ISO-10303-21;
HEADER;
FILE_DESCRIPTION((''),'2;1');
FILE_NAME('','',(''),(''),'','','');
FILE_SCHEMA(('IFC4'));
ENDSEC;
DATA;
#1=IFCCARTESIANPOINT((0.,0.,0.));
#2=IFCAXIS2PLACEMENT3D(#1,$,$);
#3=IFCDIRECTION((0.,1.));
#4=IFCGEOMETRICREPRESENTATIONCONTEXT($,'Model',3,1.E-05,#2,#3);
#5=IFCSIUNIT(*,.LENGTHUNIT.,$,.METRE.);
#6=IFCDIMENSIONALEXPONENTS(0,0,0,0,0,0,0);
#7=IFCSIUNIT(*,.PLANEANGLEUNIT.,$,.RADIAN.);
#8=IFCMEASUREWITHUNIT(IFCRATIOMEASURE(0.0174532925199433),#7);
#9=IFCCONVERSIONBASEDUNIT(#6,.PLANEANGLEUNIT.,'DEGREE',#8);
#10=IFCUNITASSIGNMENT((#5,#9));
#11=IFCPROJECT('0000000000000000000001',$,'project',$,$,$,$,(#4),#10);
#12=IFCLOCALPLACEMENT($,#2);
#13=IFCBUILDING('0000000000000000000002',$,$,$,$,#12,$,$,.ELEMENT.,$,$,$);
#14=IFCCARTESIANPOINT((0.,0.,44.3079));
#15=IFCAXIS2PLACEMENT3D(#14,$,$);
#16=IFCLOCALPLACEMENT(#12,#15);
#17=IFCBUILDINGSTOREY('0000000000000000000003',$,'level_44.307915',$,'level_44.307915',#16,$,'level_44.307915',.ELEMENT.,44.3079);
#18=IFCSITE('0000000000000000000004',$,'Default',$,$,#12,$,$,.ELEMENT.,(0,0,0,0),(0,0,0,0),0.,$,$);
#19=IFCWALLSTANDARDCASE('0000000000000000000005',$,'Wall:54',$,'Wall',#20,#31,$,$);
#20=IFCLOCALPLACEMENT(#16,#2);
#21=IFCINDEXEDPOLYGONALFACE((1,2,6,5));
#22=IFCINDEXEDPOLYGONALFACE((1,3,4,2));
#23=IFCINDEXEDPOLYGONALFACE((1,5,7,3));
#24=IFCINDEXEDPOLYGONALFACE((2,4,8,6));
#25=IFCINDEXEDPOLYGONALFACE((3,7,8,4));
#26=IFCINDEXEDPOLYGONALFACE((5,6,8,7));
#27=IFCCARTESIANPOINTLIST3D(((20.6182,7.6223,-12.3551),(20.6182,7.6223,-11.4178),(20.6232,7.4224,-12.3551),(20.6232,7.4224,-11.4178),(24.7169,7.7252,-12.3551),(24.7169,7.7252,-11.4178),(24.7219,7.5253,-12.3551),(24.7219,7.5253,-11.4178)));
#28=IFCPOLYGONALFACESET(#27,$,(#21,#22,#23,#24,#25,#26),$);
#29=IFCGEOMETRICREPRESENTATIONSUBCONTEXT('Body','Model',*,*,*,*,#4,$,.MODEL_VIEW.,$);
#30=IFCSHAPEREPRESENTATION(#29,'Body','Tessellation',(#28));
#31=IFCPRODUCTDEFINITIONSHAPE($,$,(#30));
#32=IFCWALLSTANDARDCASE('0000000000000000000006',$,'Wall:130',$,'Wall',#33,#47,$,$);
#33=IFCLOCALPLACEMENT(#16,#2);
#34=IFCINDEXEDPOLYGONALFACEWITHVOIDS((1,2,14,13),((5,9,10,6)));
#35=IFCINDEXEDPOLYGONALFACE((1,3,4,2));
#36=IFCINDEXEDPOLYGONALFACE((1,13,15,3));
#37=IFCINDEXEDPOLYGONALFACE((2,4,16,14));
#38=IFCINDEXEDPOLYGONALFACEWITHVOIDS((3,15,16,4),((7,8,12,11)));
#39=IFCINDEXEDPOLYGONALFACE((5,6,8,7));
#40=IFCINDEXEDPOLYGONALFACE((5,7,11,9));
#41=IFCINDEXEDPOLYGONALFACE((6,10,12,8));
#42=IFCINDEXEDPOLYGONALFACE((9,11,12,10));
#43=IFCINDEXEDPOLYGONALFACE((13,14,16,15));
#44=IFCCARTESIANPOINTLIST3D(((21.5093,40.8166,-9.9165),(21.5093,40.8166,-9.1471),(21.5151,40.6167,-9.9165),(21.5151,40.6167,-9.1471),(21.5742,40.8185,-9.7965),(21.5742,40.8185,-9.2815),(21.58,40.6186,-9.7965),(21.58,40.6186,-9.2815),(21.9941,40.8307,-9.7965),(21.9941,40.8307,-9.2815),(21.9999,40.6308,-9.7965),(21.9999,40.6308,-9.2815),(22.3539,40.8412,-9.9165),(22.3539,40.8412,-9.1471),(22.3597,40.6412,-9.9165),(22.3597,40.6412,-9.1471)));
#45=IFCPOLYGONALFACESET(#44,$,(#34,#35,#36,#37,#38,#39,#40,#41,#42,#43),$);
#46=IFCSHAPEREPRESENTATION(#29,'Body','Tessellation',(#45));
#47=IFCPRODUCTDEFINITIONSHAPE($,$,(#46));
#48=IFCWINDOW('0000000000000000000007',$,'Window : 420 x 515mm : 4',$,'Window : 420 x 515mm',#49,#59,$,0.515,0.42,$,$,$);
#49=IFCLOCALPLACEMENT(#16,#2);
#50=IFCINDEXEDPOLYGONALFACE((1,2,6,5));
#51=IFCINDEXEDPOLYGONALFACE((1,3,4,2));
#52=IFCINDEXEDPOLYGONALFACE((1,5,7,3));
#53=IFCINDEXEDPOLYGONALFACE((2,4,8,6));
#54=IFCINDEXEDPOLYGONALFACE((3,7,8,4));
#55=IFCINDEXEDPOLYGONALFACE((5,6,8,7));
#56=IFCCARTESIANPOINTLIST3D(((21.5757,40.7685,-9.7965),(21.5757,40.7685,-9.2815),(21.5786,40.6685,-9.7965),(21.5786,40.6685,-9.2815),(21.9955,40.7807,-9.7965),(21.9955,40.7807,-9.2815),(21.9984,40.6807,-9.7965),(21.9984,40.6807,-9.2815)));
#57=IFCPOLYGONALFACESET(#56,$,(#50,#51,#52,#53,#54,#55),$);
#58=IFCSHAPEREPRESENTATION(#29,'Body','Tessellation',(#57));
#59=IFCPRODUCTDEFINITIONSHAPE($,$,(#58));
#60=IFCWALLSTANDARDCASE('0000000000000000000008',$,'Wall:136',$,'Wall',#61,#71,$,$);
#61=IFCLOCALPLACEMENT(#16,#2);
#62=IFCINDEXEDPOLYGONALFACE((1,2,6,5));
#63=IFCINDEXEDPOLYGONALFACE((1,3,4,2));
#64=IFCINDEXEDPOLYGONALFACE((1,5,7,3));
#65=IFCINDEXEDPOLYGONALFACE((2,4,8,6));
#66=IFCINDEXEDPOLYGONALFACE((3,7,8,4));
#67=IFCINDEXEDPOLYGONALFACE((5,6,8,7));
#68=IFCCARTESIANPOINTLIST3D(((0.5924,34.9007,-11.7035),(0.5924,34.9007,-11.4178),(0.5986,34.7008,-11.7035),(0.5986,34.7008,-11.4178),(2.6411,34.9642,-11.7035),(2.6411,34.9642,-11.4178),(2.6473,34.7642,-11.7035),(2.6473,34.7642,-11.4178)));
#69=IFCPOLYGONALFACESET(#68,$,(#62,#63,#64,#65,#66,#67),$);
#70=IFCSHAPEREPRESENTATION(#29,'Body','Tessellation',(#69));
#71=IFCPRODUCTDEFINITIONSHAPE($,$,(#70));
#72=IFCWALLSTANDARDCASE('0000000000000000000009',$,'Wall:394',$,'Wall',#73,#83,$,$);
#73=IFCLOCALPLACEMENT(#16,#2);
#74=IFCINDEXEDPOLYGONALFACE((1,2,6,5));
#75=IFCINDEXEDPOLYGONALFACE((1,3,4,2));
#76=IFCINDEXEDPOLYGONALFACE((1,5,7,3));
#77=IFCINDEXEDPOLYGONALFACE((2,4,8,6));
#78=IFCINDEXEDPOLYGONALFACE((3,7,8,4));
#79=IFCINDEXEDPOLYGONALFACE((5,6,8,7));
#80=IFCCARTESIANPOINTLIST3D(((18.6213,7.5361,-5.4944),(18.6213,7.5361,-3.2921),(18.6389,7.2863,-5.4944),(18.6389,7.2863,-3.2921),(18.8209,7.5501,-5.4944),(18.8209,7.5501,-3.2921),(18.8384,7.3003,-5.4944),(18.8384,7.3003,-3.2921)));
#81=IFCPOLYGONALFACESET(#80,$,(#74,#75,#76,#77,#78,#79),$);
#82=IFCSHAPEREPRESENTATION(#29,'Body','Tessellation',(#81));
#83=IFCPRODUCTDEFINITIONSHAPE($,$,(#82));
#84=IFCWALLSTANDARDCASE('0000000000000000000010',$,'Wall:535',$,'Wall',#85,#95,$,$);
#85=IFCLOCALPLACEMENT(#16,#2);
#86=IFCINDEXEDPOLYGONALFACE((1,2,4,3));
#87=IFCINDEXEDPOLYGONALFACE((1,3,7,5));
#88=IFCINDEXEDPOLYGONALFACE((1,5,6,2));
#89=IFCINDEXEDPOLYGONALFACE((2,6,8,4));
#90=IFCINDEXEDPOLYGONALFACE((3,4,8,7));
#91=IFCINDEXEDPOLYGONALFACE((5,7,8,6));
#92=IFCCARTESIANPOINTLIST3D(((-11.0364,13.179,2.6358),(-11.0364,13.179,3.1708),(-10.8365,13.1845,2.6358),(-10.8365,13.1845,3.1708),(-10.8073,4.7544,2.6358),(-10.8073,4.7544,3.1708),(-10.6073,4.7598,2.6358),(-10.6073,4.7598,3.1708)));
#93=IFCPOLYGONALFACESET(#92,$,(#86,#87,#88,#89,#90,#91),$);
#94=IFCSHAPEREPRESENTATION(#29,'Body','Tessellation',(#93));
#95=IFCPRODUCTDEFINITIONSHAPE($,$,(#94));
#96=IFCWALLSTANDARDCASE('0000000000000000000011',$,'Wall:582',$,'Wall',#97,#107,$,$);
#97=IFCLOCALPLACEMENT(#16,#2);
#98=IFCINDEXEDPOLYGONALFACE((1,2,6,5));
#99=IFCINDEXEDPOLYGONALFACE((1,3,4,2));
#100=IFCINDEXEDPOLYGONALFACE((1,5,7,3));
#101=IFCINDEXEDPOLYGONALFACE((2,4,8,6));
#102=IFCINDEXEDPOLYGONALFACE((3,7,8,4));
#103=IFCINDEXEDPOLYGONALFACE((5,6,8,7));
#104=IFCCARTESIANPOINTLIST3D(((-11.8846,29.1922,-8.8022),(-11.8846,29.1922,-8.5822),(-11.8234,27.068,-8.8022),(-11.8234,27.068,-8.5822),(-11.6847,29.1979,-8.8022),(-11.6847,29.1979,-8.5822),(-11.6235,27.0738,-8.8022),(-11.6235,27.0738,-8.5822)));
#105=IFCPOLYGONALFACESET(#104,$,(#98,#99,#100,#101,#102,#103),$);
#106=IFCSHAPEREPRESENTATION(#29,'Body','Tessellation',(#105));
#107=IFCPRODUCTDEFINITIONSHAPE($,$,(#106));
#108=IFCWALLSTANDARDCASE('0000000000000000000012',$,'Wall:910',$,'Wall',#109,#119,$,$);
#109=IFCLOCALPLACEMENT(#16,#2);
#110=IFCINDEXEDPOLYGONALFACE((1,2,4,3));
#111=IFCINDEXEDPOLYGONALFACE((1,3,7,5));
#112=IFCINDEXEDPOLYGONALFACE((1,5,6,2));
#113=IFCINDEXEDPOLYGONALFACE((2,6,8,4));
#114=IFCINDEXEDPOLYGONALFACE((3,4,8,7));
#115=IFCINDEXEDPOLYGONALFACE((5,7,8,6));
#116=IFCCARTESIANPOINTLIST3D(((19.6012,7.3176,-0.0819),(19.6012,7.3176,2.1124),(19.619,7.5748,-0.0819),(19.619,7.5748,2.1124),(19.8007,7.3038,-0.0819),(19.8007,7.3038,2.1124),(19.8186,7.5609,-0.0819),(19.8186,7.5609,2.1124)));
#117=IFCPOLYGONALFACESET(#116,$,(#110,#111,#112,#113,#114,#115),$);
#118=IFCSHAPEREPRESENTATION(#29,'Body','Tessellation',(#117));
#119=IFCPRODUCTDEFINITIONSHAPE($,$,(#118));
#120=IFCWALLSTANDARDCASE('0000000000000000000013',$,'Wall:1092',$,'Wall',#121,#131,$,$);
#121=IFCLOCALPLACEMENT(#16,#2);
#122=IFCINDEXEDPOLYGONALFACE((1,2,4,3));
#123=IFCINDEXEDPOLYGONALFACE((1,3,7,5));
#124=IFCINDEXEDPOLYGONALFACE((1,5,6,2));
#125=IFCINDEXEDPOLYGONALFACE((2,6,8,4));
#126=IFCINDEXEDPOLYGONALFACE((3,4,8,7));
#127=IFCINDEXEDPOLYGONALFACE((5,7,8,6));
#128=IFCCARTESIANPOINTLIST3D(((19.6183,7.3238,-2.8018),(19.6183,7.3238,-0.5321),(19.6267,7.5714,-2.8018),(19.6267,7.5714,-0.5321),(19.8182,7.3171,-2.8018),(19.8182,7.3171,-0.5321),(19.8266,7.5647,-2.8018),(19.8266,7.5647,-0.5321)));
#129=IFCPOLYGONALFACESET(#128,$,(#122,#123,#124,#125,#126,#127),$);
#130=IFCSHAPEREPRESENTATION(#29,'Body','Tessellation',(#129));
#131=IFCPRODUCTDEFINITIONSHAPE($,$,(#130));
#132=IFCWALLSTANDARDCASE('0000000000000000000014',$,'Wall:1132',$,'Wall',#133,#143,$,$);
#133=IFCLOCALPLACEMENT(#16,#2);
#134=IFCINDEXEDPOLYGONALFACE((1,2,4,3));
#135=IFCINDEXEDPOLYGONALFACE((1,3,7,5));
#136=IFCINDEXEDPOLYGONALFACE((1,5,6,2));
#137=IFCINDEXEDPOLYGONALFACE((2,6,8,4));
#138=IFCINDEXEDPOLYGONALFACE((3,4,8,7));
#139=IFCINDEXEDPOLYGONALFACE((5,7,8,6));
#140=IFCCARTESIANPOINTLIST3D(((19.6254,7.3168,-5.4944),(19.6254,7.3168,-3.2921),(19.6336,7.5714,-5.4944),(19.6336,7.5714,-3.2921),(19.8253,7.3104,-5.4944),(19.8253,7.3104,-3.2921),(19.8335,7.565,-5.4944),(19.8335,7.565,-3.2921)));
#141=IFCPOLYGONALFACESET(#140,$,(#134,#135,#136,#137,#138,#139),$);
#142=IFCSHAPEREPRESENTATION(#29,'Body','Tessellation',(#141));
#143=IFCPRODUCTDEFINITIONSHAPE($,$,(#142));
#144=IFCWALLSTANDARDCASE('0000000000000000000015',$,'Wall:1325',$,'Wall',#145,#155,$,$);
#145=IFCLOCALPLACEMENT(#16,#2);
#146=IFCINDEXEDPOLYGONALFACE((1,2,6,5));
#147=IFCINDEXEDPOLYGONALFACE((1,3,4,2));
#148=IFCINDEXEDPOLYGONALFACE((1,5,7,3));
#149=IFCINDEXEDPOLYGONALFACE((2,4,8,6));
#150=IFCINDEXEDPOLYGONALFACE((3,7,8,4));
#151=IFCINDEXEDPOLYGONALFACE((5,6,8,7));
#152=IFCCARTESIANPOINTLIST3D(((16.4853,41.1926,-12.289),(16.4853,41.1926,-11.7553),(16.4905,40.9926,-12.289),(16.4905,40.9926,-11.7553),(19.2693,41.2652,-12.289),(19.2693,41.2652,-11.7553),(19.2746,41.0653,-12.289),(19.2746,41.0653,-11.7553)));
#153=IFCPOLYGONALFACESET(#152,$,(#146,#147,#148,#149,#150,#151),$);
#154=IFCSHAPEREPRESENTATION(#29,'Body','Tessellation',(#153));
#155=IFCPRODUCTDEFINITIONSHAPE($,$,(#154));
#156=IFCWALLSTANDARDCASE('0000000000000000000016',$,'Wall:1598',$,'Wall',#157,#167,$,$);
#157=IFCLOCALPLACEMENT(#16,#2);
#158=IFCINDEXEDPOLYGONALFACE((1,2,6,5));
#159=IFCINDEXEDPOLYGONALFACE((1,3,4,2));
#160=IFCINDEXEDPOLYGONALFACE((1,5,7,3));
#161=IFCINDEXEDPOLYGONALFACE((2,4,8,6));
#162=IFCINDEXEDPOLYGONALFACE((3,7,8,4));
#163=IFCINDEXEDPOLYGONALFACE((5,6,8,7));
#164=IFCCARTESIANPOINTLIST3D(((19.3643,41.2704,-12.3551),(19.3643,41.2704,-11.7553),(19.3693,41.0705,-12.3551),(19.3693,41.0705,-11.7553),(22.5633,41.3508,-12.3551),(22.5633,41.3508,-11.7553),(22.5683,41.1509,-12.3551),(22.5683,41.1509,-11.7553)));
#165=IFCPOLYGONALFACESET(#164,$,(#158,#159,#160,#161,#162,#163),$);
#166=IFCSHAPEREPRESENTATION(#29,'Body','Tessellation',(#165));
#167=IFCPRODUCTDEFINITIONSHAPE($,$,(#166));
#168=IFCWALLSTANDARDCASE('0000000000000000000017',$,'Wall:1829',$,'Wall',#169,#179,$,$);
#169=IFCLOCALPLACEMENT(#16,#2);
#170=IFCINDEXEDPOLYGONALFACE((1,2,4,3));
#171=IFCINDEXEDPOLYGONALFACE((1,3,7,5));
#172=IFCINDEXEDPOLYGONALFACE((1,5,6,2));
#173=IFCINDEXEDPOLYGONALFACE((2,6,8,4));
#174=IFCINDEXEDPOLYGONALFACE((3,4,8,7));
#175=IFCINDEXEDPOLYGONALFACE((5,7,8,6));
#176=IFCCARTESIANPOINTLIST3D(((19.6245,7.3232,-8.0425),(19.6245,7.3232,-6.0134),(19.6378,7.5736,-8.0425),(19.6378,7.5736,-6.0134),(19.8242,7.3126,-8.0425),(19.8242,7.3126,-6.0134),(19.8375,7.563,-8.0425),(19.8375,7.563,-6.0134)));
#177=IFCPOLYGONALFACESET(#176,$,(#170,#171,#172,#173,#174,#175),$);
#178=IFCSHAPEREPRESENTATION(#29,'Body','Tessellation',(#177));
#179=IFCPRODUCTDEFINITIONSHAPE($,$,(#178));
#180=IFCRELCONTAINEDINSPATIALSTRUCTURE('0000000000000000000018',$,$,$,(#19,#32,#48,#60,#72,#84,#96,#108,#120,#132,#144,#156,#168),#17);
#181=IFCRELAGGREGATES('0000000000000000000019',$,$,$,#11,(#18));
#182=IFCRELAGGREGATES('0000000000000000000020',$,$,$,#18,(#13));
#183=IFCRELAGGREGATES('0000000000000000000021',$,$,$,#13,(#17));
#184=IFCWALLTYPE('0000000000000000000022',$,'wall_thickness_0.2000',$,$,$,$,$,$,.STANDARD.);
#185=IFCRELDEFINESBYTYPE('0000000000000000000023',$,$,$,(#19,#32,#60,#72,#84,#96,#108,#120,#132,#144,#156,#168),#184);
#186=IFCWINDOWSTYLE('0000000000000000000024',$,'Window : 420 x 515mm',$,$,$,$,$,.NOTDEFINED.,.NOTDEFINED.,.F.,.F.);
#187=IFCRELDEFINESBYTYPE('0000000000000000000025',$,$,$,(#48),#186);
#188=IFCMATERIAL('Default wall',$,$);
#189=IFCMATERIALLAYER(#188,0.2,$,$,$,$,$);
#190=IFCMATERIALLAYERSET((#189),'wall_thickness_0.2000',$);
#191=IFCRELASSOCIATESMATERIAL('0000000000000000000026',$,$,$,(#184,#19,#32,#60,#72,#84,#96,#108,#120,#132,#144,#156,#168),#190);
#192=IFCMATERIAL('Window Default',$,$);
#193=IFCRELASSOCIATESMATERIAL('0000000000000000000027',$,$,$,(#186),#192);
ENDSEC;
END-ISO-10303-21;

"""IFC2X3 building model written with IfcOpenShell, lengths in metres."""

from ifc_helpers import new_model, entity, si_unit, converted_unit, direction, frame, frame_2d, origin, origin_2d_with_axis, place, context, subcontext, project, spatial, polyline, rectangle, outline, extrude, source, transform, mapped, material, layer, layer_set, layer_usage, type_object, type_shapes, element, fill, save


model = new_model("IFC2X3")

# Units and contexts
model_context = context("Model", 3, precision=1e-05, world=origin(), true_north=direction((0.0, 1.0)))
body_context = subcontext(model_context, "Body", "Model", "MODEL_VIEW")
ifc_project = project(units=[si_unit("LENGTHUNIT", "METRE"), converted_unit("PLANEANGLEUNIT", "DEGREE", entity("IfcRatioMeasure", 0.0174532925199433), si_unit("PLANEANGLEUNIT", "RADIAN"), dimensions=[0, 0, 0, 0, 0, 0, 0])], contexts=[model_context])

# Site, building, storey
placement_1 = place(None, origin())
site = spatial("IfcSite", under=ifc_project, at=placement_1, Name="Default", CompositionType="ELEMENT", RefLatitude=(0, 0, 0, 0), RefLongitude=(0, 0, 0, 0), RefElevation=0.0)
building = spatial("IfcBuilding", under=site, at=placement_1, CompositionType="ELEMENT")
storey_placement = place(placement_1, frame((0.0, 0.0, 44.3079)))
storey = spatial("IfcBuildingStorey", under=building, at=storey_placement, Name="level_44.307915", ObjectType="level_44.307915", LongName="level_44.307915", CompositionType="ELEMENT", Elevation=44.3079)

# Wall
ifc_material_1 = material(Name="Default wall")
ifc_layer = layer(ifc_material_1, 0.2)
ifc_layer_set = layer_set([ifc_layer], Name="wall_thickness_0.2000")
ifc_layer_usage = layer_usage(ifc_layer_set, "AXIS2", "POSITIVE", -0.1)
wall_type = type_object("IfcWallType", Name="wall_thickness_0.2000", PredefinedType="STANDARD", material=ifc_layer_set)
placement_2 = place(placement_1, frame((0.0, 0.0, 31.9528)))
wall_1_placement = place(placement_2, frame((20.6207, 7.5223, 0.0), z_axis=(0.0, 0.0, 1.0), x_axis=(0.999685, 0.025105, 0.0)))
element("IfcWallStandardCase", 1, at=wall_1_placement, inside=storey, type_object=wall_type, material=ifc_layer_usage, Name="Wall:54", ObjectType="Wall", context=body_context, shape_type="SweptSolid", body=[
    extrude(outline(polyline([(4.1, -0.1), (4.1, 0.1), (0.0, 0.1), (0.0, -0.1), (4.1, -0.1)])), origin(), (0.0, 0.0, 1.0), 0.9374),
])

# Wall, opening, window
placement_3 = place(placement_1, frame((0.0, 0.0, 34.3914)))
wall_2_placement = place(placement_3, frame((21.5122, 40.7166, 0.0), z_axis=(0.0, 0.0, 1.0), x_axis=(0.999577, 0.029077, 0.0)))
wall_2 = element("IfcWallStandardCase", 2, at=wall_2_placement, inside=storey, type_object=wall_type, material=ifc_layer_usage, Name="Wall:130", ObjectType="Wall", context=body_context, shape_type="SweptSolid", body=[
    extrude(outline(polyline([(0.845, -0.1), (0.845, 0.1), (0.0, 0.1), (0.0, -0.1), (0.845, -0.1)])), origin(), (0.0, 0.0, 1.0), 0.7694),
])
opening_1_placement = place(wall_2_placement, frame((0.065, -0.1, 0.12)))
opening_1 = element("IfcOpeningElement", 3, at=opening_1_placement, cuts=wall_2, ObjectType="Opening", context=body_context, shape_type="SweptSolid", body=[
    extrude(rectangle(XDim=0.42, YDim=0.515, at=frame_2d((0.2575, 0.21), x_axis=(0.0, 1.0))), frame((0.0, 0.0, 0.0), z_axis=(0.0, 1.0, 0.0), x_axis=(0.0, 0.0, 1.0)), (0.0, 0.0, 1.0), 0.2),
])
ifc_material_2 = material(Name="Window Default")
window_style_1 = type_object("IfcWindowStyle", Name="Window : 420 x 515mm", ConstructionType="NOTDEFINED", OperationType="NOTDEFINED", ParameterTakesPrecedence=False, Sizeable=False, material=ifc_material_2)
shared_shape_1 = source(origin(), body_context, "Body", "SweptSolid", [
    extrude(rectangle(XDim=0.1, YDim=0.42, at=origin_2d_with_axis()), frame((0.21, 0.1, 0.0), z_axis=(0.0, 0.0, 1.0), x_axis=(0.0, 1.0, 0.0)), (0.0, 0.0, 1.0), 0.515),
])
type_shapes(window_style_1, [shared_shape_1])
window_1_placement = place(opening_1_placement, origin())
window_1 = element("IfcWindow", 4, at=window_1_placement, inside=storey, type_object=window_style_1, Name="Window : 420 x 515mm : 4", ObjectType="Window : 420 x 515mm", OverallHeight=0.515, OverallWidth=0.42, context=body_context, shape_type="MappedRepresentation", body=[
    mapped(shared_shape_1, transform((0.0, 0.0, 0.0), scale=1.0)),
])
fill(opening_1, window_1)

# Walls
placement_4 = place(placement_1, frame((0.0, 0.0, 32.6044)))
wall_3_placement = place(placement_4, frame((0.5955, 34.8007, 0.0), z_axis=(0.0, 0.0, 1.0), x_axis=(0.99952, 0.030977, 0.0)))
element("IfcWallStandardCase", 5, at=wall_3_placement, inside=storey, type_object=wall_type, material=ifc_layer_usage, Name="Wall:136", ObjectType="Wall", context=body_context, shape_type="SweptSolid", body=[
    extrude(outline(polyline([(2.0498, -0.1), (2.0498, 0.1), (0.0, 0.1), (0.0, -0.1), (2.0498, -0.1)])), origin(), (0.0, 0.0, 1.0), 0.2857),
])
placement_5 = place(placement_1, frame((0.0, 0.0, 38.8135)))
wall_4_placement = place(placement_5, frame((18.7211, 7.5431, 0.0), z_axis=(0.0, 0.0, 1.0), x_axis=(0.069959, -0.99755, 0.0)))
element("IfcWallStandardCase", 6, at=wall_4_placement, inside=storey, type_object=wall_type, material=ifc_layer_usage, Name="Wall:394", ObjectType="Wall", context=body_context, shape_type="SweptSolid", body=[
    extrude(outline(polyline([(0.2504, -0.1), (0.2504, 0.1), (0.0, 0.1), (0.0, -0.1), (0.2504, -0.1)])), origin(), (0.0, 0.0, 1.0), 2.2023),
])
placement_6 = place(placement_1, frame((0.0, 0.0, 46.9437)))
wall_5_placement = place(placement_6, frame((-10.9364, 13.1818, 0.0), z_axis=(0.0, 0.0, 1.0), x_axis=(0.027188, -0.99963, 0.0)))
element("IfcWallStandardCase", 7, at=wall_5_placement, inside=storey, type_object=wall_type, material=ifc_layer_usage, Name="Wall:535", ObjectType="Wall", context=body_context, shape_type="SweptSolid", body=[
    extrude(outline(polyline([(8.4278, -0.1), (8.4278, 0.1), (0.0, 0.1), (0.0, -0.1), (8.4278, -0.1)])), origin(), (0.0, 0.0, 1.0), 0.535),
])
placement_7 = place(placement_1, frame((0.0, 0.0, 35.5057)))
wall_6_placement = place(placement_7, frame((-11.7847, 29.195, 0.0), z_axis=(0.0, 0.0, 1.0), x_axis=(0.028796, -0.999585, 0.0)))
element("IfcWallStandardCase", 8, at=wall_6_placement, inside=storey, type_object=wall_type, material=ifc_layer_usage, Name="Wall:582", ObjectType="Wall", context=body_context, shape_type="SweptSolid", body=[
    extrude(outline(polyline([(2.125, -0.1), (2.125, 0.1), (0.0, 0.1), (0.0, -0.1), (2.125, -0.1)])), origin(), (0.0, 0.0, 1.0), 0.22),
])
placement_8 = place(placement_1, frame((0.0, 0.0, 44.226)))
wall_7_placement = place(placement_8, frame((19.7009, 7.3107, 0.0), z_axis=(0.0, 0.0, 1.0), x_axis=(0.069309, 0.997595, 0.0)))
element("IfcWallStandardCase", 9, at=wall_7_placement, inside=storey, type_object=wall_type, material=ifc_layer_usage, Name="Wall:910", ObjectType="Wall", context=body_context, shape_type="SweptSolid", body=[
    extrude(outline(polyline([(0.2578, -0.1), (0.2578, 0.1), (0.0, 0.1), (0.0, -0.1), (0.2578, -0.1)])), origin(), (0.0, 0.0, 1.0), 2.1942),
])
placement_9 = place(placement_1, frame((0.0, 0.0, 41.5061)))
wall_8_placement = place(placement_9, frame((19.7183, 7.3204, 0.0), z_axis=(0.0, 0.0, 1.0), x_axis=(0.033777, 0.999429, 0.0)))
element("IfcWallStandardCase", 10, at=wall_8_placement, inside=storey, type_object=wall_type, material=ifc_layer_usage, Name="Wall:1092", ObjectType="Wall", context=body_context, shape_type="SweptSolid", body=[
    extrude(outline(polyline([(0.2477, -0.1), (0.2477, 0.1), (0.0, 0.1), (0.0, -0.1), (0.2477, -0.1)])), origin(), (0.0, 0.0, 1.0), 2.2697),
])
placement_10 = place(placement_1, frame((0.0, 0.0, 38.8135)))
wall_9_placement = place(placement_10, frame((19.7253, 7.3136, 0.0), z_axis=(0.0, 0.0, 1.0), x_axis=(0.032277, 0.999479, 0.0)))
element("IfcWallStandardCase", 11, at=wall_9_placement, inside=storey, type_object=wall_type, material=ifc_layer_usage, Name="Wall:1132", ObjectType="Wall", context=body_context, shape_type="SweptSolid", body=[
    extrude(outline(polyline([(0.2547, -0.1), (0.2547, 0.1), (0.0, 0.1), (0.0, -0.1), (0.2547, -0.1)])), origin(), (0.0, 0.0, 1.0), 2.2023),
])
placement_11 = place(placement_1, frame((0.0, 0.0, 32.0189)))
wall_10_placement = place(placement_11, frame((16.4879, 41.0926, 0.0), z_axis=(0.0, 0.0, 1.0), x_axis=(0.99966, 0.026093, 0.0)))
element("IfcWallStandardCase", 12, at=wall_10_placement, inside=storey, type_object=wall_type, material=ifc_layer_usage, Name="Wall:1325", ObjectType="Wall", context=body_context, shape_type="SweptSolid", body=[
    extrude(outline(polyline([(2.785, -0.1), (2.785, 0.1), (0.0, 0.1), (0.0, -0.1), (2.785, -0.1)])), origin(), (0.0, 0.0, 1.0), 0.5337),
])
placement_12 = place(placement_1, frame((0.0, 0.0, 31.9528)))
wall_11_placement = place(placement_12, frame((19.3668, 41.1704, 0.0), z_axis=(0.0, 0.0, 1.0), x_axis=(0.999684, 0.025127, 0.0)))
element("IfcWallStandardCase", 13, at=wall_11_placement, inside=storey, type_object=wall_type, material=ifc_layer_usage, Name="Wall:1598", ObjectType="Wall", context=body_context, shape_type="SweptSolid", body=[
    extrude(outline(polyline([(3.2, -0.1), (3.2, 0.1), (0.0, 0.1), (0.0, -0.1), (3.2, -0.1)])), origin(), (0.0, 0.0, 1.0), 0.5998),
])
placement_13 = place(placement_1, frame((0.0, 0.0, 36.2654)))
wall_12_placement = place(placement_13, frame((19.7244, 7.3179, 0.0), z_axis=(0.0, 0.0, 1.0), x_axis=(0.052982, 0.998595, 0.0)))
element("IfcWallStandardCase", 14, at=wall_12_placement, inside=storey, type_object=wall_type, material=ifc_layer_usage, Name="Wall:1829", ObjectType="Wall", context=body_context, shape_type="SweptSolid", body=[
    extrude(outline(polyline([(0.2507, -0.1), (0.2507, 0.1), (0.0, 0.1), (0.0, -0.1), (0.2507, -0.1)])), origin(), (0.0, 0.0, 1.0), 2.0291),
])

save(model, "model.ifc")
